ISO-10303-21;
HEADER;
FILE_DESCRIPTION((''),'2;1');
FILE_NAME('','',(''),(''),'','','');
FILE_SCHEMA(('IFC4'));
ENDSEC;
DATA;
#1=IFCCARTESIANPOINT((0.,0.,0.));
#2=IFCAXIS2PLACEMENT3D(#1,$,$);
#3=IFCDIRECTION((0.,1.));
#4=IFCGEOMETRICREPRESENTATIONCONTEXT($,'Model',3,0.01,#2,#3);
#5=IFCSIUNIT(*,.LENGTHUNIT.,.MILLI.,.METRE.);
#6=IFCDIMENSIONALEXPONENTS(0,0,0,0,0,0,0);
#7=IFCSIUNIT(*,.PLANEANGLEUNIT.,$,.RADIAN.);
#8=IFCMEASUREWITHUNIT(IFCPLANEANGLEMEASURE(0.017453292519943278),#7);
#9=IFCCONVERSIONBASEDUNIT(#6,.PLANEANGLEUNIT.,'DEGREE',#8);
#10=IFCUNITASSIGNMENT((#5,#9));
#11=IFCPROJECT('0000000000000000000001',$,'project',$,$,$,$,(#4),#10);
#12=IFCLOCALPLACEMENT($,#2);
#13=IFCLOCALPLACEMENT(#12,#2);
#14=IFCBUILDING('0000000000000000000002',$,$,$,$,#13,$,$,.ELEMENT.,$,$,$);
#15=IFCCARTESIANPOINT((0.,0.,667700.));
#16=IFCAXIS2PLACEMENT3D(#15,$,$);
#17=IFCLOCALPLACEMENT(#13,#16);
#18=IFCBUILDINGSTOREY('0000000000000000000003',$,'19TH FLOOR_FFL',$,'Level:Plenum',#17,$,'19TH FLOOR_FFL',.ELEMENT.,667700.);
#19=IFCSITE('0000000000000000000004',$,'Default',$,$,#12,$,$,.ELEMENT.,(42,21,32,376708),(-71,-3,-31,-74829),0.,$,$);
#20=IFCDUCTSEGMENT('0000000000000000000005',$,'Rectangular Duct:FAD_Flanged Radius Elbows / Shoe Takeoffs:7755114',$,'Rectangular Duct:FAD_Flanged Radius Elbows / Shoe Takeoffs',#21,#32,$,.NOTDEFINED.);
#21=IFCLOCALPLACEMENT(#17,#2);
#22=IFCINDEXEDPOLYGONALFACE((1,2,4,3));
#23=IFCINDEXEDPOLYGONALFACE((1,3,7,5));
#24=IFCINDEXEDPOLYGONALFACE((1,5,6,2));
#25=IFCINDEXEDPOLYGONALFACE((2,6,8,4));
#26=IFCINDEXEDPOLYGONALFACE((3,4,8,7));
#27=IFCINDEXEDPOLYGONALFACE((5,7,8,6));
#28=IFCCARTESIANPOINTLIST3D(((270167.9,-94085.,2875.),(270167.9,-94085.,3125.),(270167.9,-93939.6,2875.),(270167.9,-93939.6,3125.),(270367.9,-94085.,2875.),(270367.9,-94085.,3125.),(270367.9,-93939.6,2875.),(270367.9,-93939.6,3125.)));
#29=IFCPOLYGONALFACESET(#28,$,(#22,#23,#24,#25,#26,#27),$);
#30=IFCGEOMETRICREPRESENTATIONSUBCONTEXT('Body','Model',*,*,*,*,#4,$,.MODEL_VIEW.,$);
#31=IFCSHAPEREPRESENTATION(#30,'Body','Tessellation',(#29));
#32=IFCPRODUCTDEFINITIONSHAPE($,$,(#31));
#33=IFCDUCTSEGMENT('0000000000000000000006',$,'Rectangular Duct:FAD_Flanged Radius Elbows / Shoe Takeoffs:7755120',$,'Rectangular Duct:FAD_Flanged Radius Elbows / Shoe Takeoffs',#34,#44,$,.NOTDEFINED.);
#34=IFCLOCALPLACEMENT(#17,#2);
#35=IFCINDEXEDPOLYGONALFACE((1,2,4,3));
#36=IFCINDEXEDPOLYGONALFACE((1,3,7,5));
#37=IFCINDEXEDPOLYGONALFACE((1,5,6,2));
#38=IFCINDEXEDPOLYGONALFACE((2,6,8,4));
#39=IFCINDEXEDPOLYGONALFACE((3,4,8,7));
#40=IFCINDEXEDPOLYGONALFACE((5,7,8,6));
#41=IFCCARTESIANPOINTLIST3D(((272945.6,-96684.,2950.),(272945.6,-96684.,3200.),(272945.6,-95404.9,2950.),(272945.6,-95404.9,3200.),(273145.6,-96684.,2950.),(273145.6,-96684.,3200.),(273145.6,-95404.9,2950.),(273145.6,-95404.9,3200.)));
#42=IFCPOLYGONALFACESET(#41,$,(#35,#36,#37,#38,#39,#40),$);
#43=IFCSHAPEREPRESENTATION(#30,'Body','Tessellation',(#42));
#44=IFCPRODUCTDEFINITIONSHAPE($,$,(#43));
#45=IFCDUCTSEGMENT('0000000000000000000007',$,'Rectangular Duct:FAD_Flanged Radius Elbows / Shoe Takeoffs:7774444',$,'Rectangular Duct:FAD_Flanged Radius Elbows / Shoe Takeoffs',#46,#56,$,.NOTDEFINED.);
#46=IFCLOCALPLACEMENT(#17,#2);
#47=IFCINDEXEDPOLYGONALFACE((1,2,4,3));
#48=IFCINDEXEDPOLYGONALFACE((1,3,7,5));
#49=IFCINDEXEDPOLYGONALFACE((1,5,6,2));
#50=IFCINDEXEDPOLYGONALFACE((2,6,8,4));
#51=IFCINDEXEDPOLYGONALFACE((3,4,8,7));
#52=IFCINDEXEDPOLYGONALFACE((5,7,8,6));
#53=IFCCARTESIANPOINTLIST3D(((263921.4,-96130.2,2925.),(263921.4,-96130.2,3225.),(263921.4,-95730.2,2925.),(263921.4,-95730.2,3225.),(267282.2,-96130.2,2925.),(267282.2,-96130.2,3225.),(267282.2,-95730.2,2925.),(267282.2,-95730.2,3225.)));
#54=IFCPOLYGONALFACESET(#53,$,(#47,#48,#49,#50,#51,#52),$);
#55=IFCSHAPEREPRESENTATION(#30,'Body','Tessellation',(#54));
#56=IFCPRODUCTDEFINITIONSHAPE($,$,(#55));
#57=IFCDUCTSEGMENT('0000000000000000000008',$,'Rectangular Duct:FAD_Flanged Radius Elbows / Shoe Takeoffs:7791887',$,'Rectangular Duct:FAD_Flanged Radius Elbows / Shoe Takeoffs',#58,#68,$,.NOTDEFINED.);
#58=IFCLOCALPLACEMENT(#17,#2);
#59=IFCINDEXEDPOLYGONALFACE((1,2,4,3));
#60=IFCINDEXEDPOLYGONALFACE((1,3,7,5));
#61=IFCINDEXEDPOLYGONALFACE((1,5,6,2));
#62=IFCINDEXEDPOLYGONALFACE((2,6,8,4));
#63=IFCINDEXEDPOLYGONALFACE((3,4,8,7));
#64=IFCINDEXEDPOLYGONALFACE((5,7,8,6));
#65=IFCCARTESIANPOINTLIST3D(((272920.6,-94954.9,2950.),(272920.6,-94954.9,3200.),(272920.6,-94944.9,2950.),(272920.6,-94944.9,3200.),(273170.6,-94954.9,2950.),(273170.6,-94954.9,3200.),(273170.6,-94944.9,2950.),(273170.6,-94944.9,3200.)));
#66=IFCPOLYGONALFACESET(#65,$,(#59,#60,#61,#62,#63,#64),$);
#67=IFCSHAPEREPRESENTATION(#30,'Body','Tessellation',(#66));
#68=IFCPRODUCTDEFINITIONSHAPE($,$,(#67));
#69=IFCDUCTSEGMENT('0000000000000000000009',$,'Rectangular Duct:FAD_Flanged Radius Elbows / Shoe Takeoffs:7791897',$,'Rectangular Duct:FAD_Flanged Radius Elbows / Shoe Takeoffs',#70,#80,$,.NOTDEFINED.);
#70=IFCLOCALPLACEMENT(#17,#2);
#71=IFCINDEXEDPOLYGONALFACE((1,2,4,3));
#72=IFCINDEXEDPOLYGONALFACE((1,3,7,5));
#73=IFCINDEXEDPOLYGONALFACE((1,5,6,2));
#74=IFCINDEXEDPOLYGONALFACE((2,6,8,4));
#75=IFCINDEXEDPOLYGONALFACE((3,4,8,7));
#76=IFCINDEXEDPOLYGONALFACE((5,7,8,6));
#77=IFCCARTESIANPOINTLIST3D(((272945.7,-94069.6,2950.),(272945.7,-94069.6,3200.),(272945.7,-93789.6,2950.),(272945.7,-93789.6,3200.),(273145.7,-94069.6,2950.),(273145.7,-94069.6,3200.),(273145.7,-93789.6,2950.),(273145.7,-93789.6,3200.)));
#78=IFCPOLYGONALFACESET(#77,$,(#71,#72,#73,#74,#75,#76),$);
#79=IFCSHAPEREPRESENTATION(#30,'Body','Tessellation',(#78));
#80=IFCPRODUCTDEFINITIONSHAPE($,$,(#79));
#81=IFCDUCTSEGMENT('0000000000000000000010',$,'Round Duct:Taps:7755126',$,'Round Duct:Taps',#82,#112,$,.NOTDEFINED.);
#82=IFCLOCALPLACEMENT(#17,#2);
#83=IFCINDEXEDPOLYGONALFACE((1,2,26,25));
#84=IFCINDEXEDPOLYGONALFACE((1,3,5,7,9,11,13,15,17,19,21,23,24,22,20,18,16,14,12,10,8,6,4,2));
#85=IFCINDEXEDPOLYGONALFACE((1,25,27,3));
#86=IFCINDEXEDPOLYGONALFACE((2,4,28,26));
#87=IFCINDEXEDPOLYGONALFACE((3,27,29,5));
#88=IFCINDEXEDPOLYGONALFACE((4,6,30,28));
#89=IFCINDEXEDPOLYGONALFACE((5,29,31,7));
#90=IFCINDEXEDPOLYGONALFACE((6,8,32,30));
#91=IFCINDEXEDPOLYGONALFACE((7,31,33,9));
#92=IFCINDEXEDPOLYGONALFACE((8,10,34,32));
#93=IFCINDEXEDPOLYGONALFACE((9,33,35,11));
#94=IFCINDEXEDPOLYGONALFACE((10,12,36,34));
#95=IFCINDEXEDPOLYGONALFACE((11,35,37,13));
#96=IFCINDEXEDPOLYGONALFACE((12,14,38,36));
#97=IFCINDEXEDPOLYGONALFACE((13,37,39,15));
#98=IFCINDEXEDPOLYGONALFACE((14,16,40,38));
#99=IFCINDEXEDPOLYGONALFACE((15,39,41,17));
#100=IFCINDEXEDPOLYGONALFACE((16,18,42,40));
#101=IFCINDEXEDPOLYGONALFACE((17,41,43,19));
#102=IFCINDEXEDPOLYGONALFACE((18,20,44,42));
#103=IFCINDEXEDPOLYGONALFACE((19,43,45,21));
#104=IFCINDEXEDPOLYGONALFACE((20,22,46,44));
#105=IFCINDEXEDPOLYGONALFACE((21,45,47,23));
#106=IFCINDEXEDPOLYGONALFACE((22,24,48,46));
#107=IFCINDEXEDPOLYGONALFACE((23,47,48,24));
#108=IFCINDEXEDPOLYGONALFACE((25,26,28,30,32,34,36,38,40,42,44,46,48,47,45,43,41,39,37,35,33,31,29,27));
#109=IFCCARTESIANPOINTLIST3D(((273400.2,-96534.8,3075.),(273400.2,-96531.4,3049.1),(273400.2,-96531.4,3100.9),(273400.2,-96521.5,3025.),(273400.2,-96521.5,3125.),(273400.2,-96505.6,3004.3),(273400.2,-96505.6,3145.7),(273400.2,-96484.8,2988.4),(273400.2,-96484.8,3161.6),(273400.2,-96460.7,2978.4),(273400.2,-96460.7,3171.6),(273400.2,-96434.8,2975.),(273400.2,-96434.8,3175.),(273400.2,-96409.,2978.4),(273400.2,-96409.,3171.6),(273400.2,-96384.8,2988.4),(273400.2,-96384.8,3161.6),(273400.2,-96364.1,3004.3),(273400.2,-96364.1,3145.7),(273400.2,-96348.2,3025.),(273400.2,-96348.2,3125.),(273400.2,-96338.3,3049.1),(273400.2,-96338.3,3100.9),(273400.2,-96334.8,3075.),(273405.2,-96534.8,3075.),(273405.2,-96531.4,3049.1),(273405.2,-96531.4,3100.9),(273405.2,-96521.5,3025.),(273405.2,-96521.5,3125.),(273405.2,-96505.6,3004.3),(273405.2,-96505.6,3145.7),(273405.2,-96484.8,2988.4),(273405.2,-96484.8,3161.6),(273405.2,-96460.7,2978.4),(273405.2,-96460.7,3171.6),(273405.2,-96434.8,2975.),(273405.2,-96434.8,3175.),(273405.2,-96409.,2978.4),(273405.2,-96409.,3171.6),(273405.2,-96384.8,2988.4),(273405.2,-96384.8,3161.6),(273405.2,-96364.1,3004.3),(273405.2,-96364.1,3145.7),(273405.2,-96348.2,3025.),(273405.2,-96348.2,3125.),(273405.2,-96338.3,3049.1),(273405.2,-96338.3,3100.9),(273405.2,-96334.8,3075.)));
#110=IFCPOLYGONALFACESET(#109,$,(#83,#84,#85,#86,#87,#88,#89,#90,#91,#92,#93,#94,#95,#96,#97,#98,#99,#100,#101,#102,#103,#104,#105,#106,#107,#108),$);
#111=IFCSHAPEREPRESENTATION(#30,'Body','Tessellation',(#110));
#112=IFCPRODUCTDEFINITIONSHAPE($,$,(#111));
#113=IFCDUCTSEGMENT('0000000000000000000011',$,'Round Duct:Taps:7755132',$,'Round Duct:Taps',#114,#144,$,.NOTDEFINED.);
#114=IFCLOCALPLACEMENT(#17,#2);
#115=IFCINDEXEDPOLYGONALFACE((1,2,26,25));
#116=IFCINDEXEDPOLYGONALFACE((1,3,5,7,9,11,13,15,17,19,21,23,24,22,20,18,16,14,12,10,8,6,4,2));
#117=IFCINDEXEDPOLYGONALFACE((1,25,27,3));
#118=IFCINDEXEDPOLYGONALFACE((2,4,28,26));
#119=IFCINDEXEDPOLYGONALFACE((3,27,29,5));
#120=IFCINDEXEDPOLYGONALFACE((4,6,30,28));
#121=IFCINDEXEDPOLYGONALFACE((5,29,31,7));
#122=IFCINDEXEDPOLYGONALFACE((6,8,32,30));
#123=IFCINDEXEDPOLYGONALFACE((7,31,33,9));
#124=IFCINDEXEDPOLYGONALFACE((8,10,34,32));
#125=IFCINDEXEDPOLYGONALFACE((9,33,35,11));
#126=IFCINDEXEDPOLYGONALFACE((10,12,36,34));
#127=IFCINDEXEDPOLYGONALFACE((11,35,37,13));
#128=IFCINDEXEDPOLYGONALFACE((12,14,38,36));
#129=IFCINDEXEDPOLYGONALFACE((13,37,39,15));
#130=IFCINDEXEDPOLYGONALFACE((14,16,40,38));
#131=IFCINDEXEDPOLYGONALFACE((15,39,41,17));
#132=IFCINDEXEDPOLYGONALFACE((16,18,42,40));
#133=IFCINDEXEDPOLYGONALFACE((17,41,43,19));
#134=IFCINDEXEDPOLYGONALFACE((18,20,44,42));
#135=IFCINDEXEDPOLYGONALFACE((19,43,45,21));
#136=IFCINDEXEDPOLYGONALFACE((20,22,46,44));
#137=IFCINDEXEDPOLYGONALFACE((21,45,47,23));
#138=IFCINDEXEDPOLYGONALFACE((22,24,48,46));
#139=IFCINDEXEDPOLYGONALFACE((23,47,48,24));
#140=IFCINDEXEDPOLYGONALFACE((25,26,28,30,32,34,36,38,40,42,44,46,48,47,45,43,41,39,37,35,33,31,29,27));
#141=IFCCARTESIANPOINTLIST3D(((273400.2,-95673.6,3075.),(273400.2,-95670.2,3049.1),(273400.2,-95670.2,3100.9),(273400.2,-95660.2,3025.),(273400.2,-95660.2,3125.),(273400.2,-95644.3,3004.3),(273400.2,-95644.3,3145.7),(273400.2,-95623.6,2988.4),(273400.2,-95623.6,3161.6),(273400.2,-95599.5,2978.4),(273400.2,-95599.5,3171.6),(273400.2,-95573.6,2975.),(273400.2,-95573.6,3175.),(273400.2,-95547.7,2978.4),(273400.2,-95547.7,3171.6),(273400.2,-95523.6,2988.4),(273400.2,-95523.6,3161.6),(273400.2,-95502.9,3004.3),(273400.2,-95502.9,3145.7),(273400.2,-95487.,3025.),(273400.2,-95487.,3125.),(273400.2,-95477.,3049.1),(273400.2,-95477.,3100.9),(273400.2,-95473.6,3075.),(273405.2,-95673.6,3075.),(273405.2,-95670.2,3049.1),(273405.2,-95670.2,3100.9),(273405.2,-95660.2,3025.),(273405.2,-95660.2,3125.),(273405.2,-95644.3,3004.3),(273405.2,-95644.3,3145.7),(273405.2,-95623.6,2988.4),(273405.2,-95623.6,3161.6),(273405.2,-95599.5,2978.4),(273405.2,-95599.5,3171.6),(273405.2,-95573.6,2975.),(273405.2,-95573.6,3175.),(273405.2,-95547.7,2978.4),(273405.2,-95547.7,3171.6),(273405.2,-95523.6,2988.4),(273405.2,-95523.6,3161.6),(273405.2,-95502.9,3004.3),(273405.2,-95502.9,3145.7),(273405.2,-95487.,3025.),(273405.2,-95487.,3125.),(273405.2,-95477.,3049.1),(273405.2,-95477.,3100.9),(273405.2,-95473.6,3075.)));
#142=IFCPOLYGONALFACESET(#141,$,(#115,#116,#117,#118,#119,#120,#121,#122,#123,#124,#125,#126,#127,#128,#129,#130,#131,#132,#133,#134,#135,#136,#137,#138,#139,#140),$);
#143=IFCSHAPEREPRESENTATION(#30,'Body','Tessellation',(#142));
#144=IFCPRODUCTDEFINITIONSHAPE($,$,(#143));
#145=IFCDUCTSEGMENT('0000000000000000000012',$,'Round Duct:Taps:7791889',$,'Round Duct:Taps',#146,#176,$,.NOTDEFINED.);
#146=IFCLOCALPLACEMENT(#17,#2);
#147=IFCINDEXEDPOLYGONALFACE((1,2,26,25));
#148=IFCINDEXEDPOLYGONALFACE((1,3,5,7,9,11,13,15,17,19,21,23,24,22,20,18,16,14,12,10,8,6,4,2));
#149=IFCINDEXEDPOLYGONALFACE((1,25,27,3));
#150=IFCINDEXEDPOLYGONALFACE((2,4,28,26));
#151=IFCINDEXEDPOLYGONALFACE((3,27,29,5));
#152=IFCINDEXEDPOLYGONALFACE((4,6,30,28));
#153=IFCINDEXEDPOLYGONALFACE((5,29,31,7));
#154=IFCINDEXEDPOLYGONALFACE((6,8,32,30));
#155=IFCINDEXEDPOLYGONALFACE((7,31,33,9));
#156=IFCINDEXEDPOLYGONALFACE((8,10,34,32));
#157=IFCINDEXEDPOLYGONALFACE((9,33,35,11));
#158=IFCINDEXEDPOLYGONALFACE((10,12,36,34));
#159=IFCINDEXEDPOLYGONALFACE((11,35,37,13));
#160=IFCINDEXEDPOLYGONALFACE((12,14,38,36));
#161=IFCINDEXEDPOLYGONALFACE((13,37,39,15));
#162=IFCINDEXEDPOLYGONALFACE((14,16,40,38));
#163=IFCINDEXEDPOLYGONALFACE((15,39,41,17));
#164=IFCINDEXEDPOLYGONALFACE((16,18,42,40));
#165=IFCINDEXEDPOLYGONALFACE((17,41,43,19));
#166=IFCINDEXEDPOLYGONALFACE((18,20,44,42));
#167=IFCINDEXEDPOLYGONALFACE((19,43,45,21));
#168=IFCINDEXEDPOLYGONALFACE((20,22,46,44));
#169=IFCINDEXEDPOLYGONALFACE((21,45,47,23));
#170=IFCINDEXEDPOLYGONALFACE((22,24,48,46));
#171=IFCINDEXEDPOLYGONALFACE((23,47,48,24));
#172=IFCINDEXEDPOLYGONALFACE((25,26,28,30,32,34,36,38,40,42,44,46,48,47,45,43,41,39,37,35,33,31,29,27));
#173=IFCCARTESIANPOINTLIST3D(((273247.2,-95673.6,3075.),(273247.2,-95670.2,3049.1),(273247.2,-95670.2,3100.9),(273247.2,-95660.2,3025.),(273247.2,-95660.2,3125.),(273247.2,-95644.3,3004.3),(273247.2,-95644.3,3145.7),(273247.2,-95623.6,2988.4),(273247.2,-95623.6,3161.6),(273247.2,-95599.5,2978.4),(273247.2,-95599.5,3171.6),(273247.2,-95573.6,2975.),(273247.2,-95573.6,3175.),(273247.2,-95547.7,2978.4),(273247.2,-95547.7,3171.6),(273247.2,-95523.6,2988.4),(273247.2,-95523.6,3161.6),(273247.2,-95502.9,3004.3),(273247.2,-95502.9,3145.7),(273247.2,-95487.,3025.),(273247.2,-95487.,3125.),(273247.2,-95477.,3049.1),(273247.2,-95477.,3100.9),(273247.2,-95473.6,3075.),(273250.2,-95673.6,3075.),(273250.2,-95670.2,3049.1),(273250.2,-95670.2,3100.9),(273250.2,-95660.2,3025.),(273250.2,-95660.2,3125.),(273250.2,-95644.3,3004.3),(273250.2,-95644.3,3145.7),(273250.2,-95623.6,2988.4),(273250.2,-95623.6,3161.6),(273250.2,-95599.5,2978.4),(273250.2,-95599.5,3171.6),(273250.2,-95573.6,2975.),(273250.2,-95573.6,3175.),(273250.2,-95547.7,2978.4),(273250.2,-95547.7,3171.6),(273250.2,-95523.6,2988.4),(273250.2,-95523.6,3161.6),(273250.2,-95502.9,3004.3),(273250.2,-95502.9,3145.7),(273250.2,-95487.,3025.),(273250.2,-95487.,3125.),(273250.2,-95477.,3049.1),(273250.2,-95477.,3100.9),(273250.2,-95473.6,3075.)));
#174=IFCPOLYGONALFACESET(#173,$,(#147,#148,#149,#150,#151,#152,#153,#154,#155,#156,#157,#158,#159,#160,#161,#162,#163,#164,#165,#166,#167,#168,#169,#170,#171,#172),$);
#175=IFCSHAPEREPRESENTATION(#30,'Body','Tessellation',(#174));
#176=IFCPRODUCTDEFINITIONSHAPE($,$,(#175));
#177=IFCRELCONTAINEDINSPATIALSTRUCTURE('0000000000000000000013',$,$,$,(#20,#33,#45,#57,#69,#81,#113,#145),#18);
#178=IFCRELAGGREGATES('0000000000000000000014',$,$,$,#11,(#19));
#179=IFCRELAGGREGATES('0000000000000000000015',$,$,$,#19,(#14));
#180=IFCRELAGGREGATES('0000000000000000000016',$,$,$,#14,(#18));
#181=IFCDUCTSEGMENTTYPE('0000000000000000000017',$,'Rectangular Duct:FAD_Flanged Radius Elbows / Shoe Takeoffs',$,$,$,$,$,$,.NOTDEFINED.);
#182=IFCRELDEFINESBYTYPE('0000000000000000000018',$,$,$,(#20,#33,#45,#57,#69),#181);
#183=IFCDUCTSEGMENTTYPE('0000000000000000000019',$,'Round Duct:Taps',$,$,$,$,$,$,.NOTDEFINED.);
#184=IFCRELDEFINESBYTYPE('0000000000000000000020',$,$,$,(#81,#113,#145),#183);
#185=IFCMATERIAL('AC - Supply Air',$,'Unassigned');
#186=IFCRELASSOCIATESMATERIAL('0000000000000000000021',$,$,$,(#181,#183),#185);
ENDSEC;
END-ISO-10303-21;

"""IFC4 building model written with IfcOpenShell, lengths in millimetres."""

from ifc_helpers import new_model, entity, si_unit, converted_unit, direction, frame, origin, place, context, subcontext, project, spatial, arc, indexed_curve, outline, extrude, material, type_object, element, save


model = new_model("IFC4")

# Units and contexts
model_context = context("Model", 3, precision=0.01, world=origin(), true_north=direction((0.0, 1.0)))
body_context = subcontext(model_context, "Body", "Model", "MODEL_VIEW")
ifc_project = project(units=[si_unit("LENGTHUNIT", "METRE", prefix="MILLI"), converted_unit("PLANEANGLEUNIT", "DEGREE", entity("IfcPlaneAngleMeasure", 0.017453292519943278), si_unit("PLANEANGLEUNIT", "RADIAN"), dimensions=[0, 0, 0, 0, 0, 0, 0])], contexts=[model_context])

# Site, building, storey
site_placement = place(None, origin())
site = spatial("IfcSite", under=ifc_project, at=site_placement, Name="Default", CompositionType="ELEMENT", RefLatitude=(42, 21, 32, 376708), RefLongitude=(-71, -3, -31, -74829), RefElevation=0.0)
building_placement = place(site_placement, origin())
building = spatial("IfcBuilding", under=site, at=building_placement, CompositionType="ELEMENT")
storey_placement = place(building_placement, frame((0.0, 0.0, 667700.0)))
storey = spatial("IfcBuildingStorey", under=building, at=storey_placement, Name="19TH FLOOR_FFL", ObjectType="Level:Plenum", LongName="19TH FLOOR_FFL", CompositionType="ELEMENT", Elevation=667700.0)

# Duct segments
ifc_material_1 = material(Name="AC - Supply Air", Category="Unassigned")
duct_segment_type_1 = type_object("IfcDuctSegmentType", Name="Rectangular Duct:FAD_Flanged Radius Elbows / Shoe Takeoffs", PredefinedType="NOTDEFINED", material=ifc_material_1)
duct_segment_1_placement = place(storey_placement, origin())
element("IfcDuctSegment", 1, at=duct_segment_1_placement, inside=storey, type_object=duct_segment_type_1, Name="Rectangular Duct:FAD_Flanged Radius Elbows / Shoe Takeoffs:7755114", ObjectType="Rectangular Duct:FAD_Flanged Radius Elbows / Shoe Takeoffs", PredefinedType="NOTDEFINED", context=body_context, shape_type="SweptSolid", body=[
    extrude(outline(indexed_curve([(-72.7, -100.0), (72.7, -100.0), (72.7, 100.0), (-72.7, 100.0), (-72.7, -100.0)], self_intersect=False)), frame((270267.9, -94012.3, 2875.0), z_axis=(0.0, 0.0, 1.0), x_axis=(0.0, 1.0, 0.0)), (0.0, 0.0, 1.0), 250.0),
])
duct_segment_2_placement = place(storey_placement, origin())
element("IfcDuctSegment", 2, at=duct_segment_2_placement, inside=storey, type_object=duct_segment_type_1, Name="Rectangular Duct:FAD_Flanged Radius Elbows / Shoe Takeoffs:7755120", ObjectType="Rectangular Duct:FAD_Flanged Radius Elbows / Shoe Takeoffs", PredefinedType="NOTDEFINED", context=body_context, shape_type="SweptSolid", body=[
    extrude(outline(indexed_curve([(-639.5, -100.0), (639.5, -100.0), (639.5, 100.0), (-639.5, 100.0), (-639.5, -100.0)], self_intersect=False)), frame((273045.6, -96044.4, 2950.0), z_axis=(0.0, 0.0, 1.0), x_axis=(0.0, 1.0, 0.0)), (0.0, 0.0, 1.0), 250.0),
])
duct_segment_3_placement = place(storey_placement, origin())
element("IfcDuctSegment", 3, at=duct_segment_3_placement, inside=storey, type_object=duct_segment_type_1, Name="Rectangular Duct:FAD_Flanged Radius Elbows / Shoe Takeoffs:7774444", ObjectType="Rectangular Duct:FAD_Flanged Radius Elbows / Shoe Takeoffs", PredefinedType="NOTDEFINED", context=body_context, shape_type="SweptSolid", body=[
    extrude(outline(indexed_curve([(-1680.4, -200.0), (1680.4, -200.0), (1680.4, 200.0), (-1680.4, 200.0), (-1680.4, -200.0)], self_intersect=False)), frame((265601.8, -95930.2, 2925.0), z_axis=(0.0, 0.0, 1.0), x_axis=(-1.0, 0.0, 0.0)), (0.0, 0.0, 1.0), 300.0),
])
duct_segment_4_placement = place(storey_placement, origin())
element("IfcDuctSegment", 4, at=duct_segment_4_placement, inside=storey, type_object=duct_segment_type_1, Name="Rectangular Duct:FAD_Flanged Radius Elbows / Shoe Takeoffs:7791887", ObjectType="Rectangular Duct:FAD_Flanged Radius Elbows / Shoe Takeoffs", PredefinedType="NOTDEFINED", context=body_context, shape_type="SweptSolid", body=[
    extrude(outline(indexed_curve([(-5.0, -125.0), (5.0, -125.0), (5.0, 125.0), (-5.0, 125.0), (-5.0, -125.0)], self_intersect=False)), frame((273045.6, -94949.9, 2950.0), z_axis=(0.0, 0.0, 1.0), x_axis=(0.0, -1.0, 0.0)), (0.0, 0.0, 1.0), 250.0),
])
duct_segment_5_placement = place(storey_placement, origin())
element("IfcDuctSegment", 5, at=duct_segment_5_placement, inside=storey, type_object=duct_segment_type_1, Name="Rectangular Duct:FAD_Flanged Radius Elbows / Shoe Takeoffs:7791897", ObjectType="Rectangular Duct:FAD_Flanged Radius Elbows / Shoe Takeoffs", PredefinedType="NOTDEFINED", context=body_context, shape_type="SweptSolid", body=[
    extrude(outline(indexed_curve([(-140.0, -100.0), (140.0, -100.0), (140.0, 100.0), (-140.0, 100.0), (-140.0, -100.0)], self_intersect=False)), frame((273045.7, -93929.6, 2950.0), z_axis=(0.0, 0.0, 1.0), x_axis=(0.0, -1.0, 0.0)), (0.0, 0.0, 1.0), 250.0),
])
duct_segment_type_2 = type_object("IfcDuctSegmentType", Name="Round Duct:Taps", PredefinedType="NOTDEFINED", material=ifc_material_1)
duct_segment_6_placement = place(storey_placement, origin())
element("IfcDuctSegment", 6, at=duct_segment_6_placement, inside=storey, type_object=duct_segment_type_2, Name="Round Duct:Taps:7755126", ObjectType="Round Duct:Taps", PredefinedType="NOTDEFINED", context=body_context, shape_type="SweptSolid", body=[
    extrude(outline(indexed_curve([(100.0, 0.0), (70.7, 70.7), (0.0, 100.0), (-70.7, 70.7), (-100.0, 0.0), (-70.7, -70.7), (0.0, -100.0), (70.7, -70.7)], segments=[arc(1, 2, 3), arc(3, 4, 5), arc(5, 6, 7), arc(7, 8, 1)], self_intersect=False)), frame((273400.2, -96434.8, 3075.0), z_axis=(1.0, 0.0, 0.0), x_axis=(0.0, -1.0, 0.0)), (0.0, 0.0, 1.0), 5.0),
])
duct_segment_7_placement = place(storey_placement, origin())
element("IfcDuctSegment", 7, at=duct_segment_7_placement, inside=storey, type_object=duct_segment_type_2, Name="Round Duct:Taps:7755132", ObjectType="Round Duct:Taps", PredefinedType="NOTDEFINED", context=body_context, shape_type="SweptSolid", body=[
    extrude(outline(indexed_curve([(100.0, 0.0), (70.7, 70.7), (0.0, 100.0), (-70.7, 70.7), (-100.0, 0.0), (-70.7, -70.7), (0.0, -100.0), (70.7, -70.7)], segments=[arc(1, 2, 3), arc(3, 4, 5), arc(5, 6, 7), arc(7, 8, 1)], self_intersect=False)), frame((273400.2, -95573.6, 3075.0), z_axis=(1.0, 0.0, 0.0), x_axis=(0.0, -1.0, 0.0)), (0.0, 0.0, 1.0), 5.0),
])
duct_segment_8_placement = place(storey_placement, origin())
element("IfcDuctSegment", 8, at=duct_segment_8_placement, inside=storey, type_object=duct_segment_type_2, Name="Round Duct:Taps:7791889", ObjectType="Round Duct:Taps", PredefinedType="NOTDEFINED", context=body_context, shape_type="SweptSolid", body=[
    extrude(outline(indexed_curve([(100.0, 0.0), (70.7, 70.7), (0.0, 100.0), (-70.7, 70.7), (-100.0, 0.0), (-70.7, -70.7), (0.0, -100.0), (70.7, -70.7)], segments=[arc(1, 2, 3), arc(3, 4, 5), arc(5, 6, 7), arc(7, 8, 1)], self_intersect=False)), frame((273247.2, -95573.6, 3075.0), z_axis=(1.0, 0.0, 0.0), x_axis=(0.0, -1.0, 0.0)), (0.0, 0.0, 1.0), 3.0),
])

save(model, "model.ifc")
